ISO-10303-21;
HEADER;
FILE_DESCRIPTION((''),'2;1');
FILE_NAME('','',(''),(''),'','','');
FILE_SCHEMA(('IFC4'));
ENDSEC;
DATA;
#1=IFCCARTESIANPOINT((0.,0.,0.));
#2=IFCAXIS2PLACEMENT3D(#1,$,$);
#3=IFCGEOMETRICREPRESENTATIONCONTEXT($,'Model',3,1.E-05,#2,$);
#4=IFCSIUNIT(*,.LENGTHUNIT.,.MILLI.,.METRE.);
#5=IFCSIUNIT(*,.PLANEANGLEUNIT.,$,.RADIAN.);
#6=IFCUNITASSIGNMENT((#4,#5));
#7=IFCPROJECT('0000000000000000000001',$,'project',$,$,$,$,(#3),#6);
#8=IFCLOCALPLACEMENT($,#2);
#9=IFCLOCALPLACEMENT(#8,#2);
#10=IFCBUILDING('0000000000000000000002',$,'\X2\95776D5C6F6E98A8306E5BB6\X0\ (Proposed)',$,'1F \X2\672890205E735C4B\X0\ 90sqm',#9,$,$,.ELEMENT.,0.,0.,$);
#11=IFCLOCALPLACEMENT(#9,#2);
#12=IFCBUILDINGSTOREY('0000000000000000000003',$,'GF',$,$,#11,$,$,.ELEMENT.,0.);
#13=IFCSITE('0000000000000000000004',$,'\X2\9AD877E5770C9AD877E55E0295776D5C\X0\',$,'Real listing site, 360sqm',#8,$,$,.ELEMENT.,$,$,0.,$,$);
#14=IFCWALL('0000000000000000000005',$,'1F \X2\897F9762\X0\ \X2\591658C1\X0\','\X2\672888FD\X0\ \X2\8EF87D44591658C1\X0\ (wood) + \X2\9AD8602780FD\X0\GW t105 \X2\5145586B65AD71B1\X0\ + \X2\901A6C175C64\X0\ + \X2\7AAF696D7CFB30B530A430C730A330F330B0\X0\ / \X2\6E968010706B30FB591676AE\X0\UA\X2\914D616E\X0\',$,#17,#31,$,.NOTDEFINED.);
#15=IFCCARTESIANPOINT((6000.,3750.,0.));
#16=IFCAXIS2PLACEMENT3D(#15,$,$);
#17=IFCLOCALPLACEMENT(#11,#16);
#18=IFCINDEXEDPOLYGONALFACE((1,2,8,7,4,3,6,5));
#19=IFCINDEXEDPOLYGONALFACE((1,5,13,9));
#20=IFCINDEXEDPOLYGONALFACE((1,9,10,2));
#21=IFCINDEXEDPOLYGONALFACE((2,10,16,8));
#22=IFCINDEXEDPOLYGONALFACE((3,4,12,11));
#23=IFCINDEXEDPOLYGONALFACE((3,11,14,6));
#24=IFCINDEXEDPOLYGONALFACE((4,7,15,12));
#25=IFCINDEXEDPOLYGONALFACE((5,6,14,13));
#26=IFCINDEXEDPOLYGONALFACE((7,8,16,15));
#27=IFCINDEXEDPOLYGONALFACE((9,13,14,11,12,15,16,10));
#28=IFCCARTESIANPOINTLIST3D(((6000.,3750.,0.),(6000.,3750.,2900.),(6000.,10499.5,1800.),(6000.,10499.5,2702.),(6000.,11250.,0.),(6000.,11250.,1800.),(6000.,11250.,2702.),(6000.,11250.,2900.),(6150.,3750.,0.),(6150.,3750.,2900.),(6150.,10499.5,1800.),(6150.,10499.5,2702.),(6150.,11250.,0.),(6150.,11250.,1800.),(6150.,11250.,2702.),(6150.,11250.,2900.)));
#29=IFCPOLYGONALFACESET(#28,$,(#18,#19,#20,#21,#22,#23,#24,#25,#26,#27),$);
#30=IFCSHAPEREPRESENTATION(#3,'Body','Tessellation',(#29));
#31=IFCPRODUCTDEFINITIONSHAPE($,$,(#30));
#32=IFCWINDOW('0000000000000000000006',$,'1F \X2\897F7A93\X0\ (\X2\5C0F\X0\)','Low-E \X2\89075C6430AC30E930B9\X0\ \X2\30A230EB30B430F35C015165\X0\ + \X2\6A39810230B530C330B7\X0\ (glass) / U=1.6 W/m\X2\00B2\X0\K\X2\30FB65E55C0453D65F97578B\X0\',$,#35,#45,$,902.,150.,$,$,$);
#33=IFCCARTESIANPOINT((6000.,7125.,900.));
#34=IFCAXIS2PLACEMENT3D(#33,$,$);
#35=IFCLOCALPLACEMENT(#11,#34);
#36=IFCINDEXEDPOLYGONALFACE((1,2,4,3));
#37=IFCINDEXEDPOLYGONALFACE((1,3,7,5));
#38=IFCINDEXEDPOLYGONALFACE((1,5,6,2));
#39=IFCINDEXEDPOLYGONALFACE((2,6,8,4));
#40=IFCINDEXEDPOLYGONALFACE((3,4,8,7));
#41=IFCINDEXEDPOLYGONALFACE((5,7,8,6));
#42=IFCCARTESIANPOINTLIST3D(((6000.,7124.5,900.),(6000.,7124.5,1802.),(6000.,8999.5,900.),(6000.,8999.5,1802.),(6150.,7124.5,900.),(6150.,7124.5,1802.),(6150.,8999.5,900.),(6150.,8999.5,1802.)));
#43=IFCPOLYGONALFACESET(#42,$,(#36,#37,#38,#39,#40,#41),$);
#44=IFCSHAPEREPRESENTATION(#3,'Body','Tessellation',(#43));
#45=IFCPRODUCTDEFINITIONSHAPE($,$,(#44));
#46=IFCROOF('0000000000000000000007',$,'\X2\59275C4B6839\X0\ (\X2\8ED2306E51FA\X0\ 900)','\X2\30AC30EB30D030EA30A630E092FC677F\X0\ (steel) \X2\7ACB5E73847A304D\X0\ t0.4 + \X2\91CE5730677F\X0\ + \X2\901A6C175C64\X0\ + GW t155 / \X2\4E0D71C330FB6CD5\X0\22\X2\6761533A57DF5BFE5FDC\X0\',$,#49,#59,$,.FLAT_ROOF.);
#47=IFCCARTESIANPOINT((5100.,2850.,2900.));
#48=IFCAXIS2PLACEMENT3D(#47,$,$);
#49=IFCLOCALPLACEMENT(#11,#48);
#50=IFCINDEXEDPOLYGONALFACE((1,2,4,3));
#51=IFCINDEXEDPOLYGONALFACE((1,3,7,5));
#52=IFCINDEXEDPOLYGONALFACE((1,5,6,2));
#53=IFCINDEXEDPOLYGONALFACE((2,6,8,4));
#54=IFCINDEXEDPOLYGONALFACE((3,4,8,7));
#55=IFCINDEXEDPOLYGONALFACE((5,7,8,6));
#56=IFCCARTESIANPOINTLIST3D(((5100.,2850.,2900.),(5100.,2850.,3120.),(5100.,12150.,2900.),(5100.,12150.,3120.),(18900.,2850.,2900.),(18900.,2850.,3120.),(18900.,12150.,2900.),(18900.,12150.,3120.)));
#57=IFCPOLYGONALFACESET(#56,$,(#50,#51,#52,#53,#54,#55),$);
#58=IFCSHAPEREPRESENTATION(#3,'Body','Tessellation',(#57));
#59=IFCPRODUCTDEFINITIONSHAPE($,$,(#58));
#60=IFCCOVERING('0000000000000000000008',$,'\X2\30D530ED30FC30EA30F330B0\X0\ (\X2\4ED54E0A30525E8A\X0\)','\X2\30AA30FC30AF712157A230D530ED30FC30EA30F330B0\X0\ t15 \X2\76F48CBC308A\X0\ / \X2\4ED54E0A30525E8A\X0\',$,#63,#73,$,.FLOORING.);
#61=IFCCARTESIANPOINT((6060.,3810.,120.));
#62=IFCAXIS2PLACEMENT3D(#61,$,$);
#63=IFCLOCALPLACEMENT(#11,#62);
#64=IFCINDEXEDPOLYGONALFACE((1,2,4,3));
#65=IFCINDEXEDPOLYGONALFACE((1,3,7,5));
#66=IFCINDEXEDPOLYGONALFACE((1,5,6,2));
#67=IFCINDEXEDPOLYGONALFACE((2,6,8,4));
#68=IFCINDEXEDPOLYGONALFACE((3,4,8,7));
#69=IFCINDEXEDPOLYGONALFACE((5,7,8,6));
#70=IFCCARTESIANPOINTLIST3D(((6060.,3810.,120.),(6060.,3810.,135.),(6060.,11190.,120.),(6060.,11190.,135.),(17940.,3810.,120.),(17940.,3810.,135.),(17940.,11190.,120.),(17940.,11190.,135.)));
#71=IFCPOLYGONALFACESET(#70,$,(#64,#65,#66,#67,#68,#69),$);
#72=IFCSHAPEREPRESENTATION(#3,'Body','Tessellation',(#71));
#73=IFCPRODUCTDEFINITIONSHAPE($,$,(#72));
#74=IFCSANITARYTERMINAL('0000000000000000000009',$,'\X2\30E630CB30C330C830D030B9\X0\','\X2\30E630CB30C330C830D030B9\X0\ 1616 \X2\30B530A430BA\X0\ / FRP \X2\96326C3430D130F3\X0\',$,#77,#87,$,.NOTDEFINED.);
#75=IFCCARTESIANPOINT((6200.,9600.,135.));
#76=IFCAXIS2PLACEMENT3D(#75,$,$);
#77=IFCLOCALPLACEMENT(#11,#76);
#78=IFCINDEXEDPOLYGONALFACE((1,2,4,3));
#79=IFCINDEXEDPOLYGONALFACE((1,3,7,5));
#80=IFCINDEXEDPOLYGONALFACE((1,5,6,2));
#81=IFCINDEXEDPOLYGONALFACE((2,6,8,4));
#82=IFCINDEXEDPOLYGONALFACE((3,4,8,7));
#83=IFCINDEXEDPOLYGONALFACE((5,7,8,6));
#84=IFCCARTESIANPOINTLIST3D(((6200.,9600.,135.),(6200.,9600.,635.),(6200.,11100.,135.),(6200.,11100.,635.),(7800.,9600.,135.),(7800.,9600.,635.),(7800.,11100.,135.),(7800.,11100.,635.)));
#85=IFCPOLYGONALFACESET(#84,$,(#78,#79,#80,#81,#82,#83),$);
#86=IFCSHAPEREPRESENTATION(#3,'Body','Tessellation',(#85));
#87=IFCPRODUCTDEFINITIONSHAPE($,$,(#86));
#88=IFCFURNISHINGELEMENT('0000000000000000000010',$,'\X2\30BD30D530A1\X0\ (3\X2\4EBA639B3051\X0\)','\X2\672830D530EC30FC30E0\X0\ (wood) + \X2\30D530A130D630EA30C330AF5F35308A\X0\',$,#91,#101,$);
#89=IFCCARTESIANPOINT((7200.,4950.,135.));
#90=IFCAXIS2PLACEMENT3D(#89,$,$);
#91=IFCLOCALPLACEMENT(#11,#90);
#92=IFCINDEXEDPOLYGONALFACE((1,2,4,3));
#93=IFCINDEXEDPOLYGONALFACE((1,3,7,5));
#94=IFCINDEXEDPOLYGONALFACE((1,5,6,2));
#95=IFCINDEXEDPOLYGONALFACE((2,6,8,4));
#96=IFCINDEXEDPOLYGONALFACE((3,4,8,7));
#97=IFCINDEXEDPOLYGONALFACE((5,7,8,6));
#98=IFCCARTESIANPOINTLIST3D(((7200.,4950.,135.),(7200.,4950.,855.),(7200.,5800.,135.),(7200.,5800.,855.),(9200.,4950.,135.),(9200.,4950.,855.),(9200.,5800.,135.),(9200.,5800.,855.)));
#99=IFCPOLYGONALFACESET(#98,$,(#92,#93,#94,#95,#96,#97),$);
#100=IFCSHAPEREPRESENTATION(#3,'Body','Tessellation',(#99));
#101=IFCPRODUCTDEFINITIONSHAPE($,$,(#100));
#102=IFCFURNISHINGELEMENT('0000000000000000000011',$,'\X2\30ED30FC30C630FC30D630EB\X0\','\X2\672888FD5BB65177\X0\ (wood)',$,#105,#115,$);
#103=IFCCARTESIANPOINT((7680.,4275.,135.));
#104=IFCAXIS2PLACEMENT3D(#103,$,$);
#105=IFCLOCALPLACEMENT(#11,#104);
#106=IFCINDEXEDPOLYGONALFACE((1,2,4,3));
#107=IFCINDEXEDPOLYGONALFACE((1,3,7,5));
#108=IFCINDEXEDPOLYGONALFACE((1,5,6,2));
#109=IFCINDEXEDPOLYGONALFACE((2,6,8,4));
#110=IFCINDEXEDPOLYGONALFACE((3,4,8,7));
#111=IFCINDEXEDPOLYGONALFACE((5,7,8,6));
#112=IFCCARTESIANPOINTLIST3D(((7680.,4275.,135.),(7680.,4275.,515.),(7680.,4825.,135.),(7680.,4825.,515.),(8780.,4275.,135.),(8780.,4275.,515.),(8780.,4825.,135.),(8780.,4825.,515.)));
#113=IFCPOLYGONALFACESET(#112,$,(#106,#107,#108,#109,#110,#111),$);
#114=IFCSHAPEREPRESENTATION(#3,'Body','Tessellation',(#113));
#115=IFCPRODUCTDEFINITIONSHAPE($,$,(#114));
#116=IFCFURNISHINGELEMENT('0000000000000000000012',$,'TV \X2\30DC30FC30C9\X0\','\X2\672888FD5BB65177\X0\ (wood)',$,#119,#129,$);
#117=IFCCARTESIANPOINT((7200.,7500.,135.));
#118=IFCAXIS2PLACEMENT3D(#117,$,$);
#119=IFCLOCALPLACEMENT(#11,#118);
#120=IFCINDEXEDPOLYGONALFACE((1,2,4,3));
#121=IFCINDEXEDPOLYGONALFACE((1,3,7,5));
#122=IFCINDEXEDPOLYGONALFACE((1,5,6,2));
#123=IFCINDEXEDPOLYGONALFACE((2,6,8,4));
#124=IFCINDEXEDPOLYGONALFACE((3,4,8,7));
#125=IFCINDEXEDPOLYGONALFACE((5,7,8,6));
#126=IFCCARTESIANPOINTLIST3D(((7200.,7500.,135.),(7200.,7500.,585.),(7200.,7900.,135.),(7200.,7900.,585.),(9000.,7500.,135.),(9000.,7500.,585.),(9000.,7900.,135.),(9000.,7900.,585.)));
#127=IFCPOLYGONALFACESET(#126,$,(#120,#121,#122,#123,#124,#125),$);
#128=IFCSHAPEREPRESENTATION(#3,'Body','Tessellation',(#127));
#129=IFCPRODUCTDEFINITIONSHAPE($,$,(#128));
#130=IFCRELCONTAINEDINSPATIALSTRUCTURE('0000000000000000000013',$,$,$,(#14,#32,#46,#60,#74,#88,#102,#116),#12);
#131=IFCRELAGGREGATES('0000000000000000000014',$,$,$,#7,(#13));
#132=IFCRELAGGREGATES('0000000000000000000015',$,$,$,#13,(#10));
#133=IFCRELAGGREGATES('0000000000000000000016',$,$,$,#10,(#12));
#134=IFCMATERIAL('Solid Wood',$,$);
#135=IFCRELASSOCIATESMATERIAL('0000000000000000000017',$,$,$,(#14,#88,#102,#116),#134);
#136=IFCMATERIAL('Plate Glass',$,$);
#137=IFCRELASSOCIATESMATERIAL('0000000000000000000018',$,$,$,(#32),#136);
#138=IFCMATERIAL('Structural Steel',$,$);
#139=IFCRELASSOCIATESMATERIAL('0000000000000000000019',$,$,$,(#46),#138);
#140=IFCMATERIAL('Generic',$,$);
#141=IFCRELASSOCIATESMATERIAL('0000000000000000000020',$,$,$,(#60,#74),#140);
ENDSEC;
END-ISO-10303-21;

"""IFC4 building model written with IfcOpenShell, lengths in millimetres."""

from ifc_helpers import new_model, si_unit, frame, frame_2d, origin, place, context, project, spatial, rectangle, extrude, material, element, fill, save


model = new_model("IFC4")

# Units and contexts
model_context = context("Model", 3, precision=1e-05, world=origin())
ifc_project = project(units=[si_unit("LENGTHUNIT", "METRE", prefix="MILLI"), si_unit("PLANEANGLEUNIT", "RADIAN")], contexts=[model_context])

# Site, building, storey
site_placement = place(None, origin())
site = spatial("IfcSite", under=ifc_project, at=site_placement, Name="高知県高知市長浜", ObjectType="Real listing site, 360sqm", CompositionType="ELEMENT", RefElevation=0.0)
building_placement = place(site_placement, origin())
building = spatial("IfcBuilding", under=site, at=building_placement, Name="長浜潮風の家 (Proposed)", ObjectType="1F 木造平屋 90sqm", CompositionType="ELEMENT", ElevationOfRefHeight=0.0, ElevationOfTerrain=0.0)
storey_placement = place(building_placement, origin())
storey = spatial("IfcBuildingStorey", under=building, at=storey_placement, Name="GF", CompositionType="ELEMENT", Elevation=0.0)

# Shared definitions
ifc_material_1 = material(Name="Solid Wood")

# Shared definitions
ifc_material_2 = material(Name="Plate Glass")

# Wall, opening, window
wall_1_placement = place(storey_placement, frame((6000.0, 3750.0, 0.0)))
wall_1 = element("IfcWall", 1, at=wall_1_placement, inside=storey, material=ifc_material_1, Name="1F 西面 外壁", Description="木製 軸組外壁 (wood) + 高性能GW t105 充填断熱 + 通気層 + 窯業系サイディング / 準耐火・外皮UA配慮", PredefinedType="NOTDEFINED", context=model_context, shape_type="SweptSolid", body=[
    extrude(rectangle(XDim=150.0, YDim=7500.0, at=frame_2d((75.0, 3750.0))), frame((6000.0, 3750.0, 0.0)), (0.0, 0.0, 1.0), 2900.0),
])
opening_1_placement = place(storey_placement, frame((6000.0, 7125.0, 900.0)))
opening_1 = element("IfcOpeningElement", 2, at=opening_1_placement, cuts=wall_1, PredefinedType="NOTDEFINED", context=model_context, shape_type="SweptSolid", body=[
    extrude(rectangle(XDim=150.0, YDim=1875.0, at=frame_2d((75.0, 937.0))), frame((6000.0, 7125.0, 900.0)), (0.0, 0.0, 1.0), 902.0),
])
window_1_placement = place(storey_placement, frame((6000.0, 7125.0, 900.0)))
window_1 = element("IfcWindow", 3, at=window_1_placement, inside=storey, material=ifc_material_2, Name="1F 西窓 (小)", Description="Low-E 複層ガラス アルゴン封入 + 樹脂サッシ (glass) / U=1.6 W/m²K・日射取得型", OverallHeight=902.0, OverallWidth=150.0, context=model_context, shape_type="SweptSolid", body=[
    extrude(rectangle(XDim=150.0, YDim=1875.0, at=frame_2d((75.0, 937.0))), frame((6000.0, 7125.0, 900.0)), (0.0, 0.0, 1.0), 902.0),
])
fill(opening_1, window_1)

# Roof
ifc_material_3 = material(Name="Structural Steel")
roof_placement = place(storey_placement, frame((5100.0, 2850.0, 2900.0)))
element("IfcRoof", 4, at=roof_placement, inside=storey, material=ifc_material_3, Name="大屋根 (軒の出 900)", Description="ガルバリウム鋼板 (steel) 立平葺き t0.4 + 野地板 + 通気層 + GW t155 / 不燃・法22条区域対応", PredefinedType="FLAT_ROOF", context=model_context, shape_type="SweptSolid", body=[
    extrude(rectangle(XDim=13800.0, YDim=9300.0, at=frame_2d((6900.0, 4650.0))), frame((5100.0, 2850.0, 2900.0)), (0.0, 0.0, 1.0), 220.0),
])

# Covering
ifc_material_4 = material(Name="Generic")
covering_placement = place(storey_placement, frame((6060.0, 3810.0, 120.0)))
element("IfcCovering", 5, at=covering_placement, inside=storey, material=ifc_material_4, Name="フローリング (仕上げ床)", Description="オーク無垢フローリング t15 直貼り / 仕上げ床", PredefinedType="FLOORING", context=model_context, shape_type="SweptSolid", body=[
    extrude(rectangle(XDim=11880.0, YDim=7380.0, at=frame_2d((5940.0, 3690.0))), frame((6060.0, 3810.0, 120.0)), (0.0, 0.0, 1.0), 15.0),
])

# Sanitary terminal
sanitary_terminal_placement = place(storey_placement, frame((6200.0, 9600.0, 135.0)))
element("IfcSanitaryTerminal", 6, at=sanitary_terminal_placement, inside=storey, material=ifc_material_4, Name="ユニットバス", Description="ユニットバス 1616 サイズ / FRP 防水パン", PredefinedType="NOTDEFINED", context=model_context, shape_type="SweptSolid", body=[
    extrude(rectangle(XDim=1600.0, YDim=1500.0, at=frame_2d((800.0, 750.0))), frame((6200.0, 9600.0, 135.0)), (0.0, 0.0, 1.0), 500.0),
])

# Furnishing elements
furnishing_1_placement = place(storey_placement, frame((7200.0, 4950.0, 135.0)))
element("IfcFurnishingElement", 7, at=furnishing_1_placement, inside=storey, material=ifc_material_1, Name="ソファ (3人掛け)", Description="木フレーム (wood) + ファブリック張り", context=model_context, shape_type="SweptSolid", body=[
    extrude(rectangle(XDim=2000.0, YDim=850.0, at=frame_2d((1000.0, 425.0))), frame((7200.0, 4950.0, 135.0)), (0.0, 0.0, 1.0), 720.0),
])
furnishing_2_placement = place(storey_placement, frame((7680.0, 4275.0, 135.0)))
element("IfcFurnishingElement", 8, at=furnishing_2_placement, inside=storey, material=ifc_material_1, Name="ローテーブル", Description="木製家具 (wood)", context=model_context, shape_type="SweptSolid", body=[
    extrude(rectangle(XDim=1100.0, YDim=550.0, at=frame_2d((550.0, 275.0))), frame((7680.0, 4275.0, 135.0)), (0.0, 0.0, 1.0), 380.0),
])
furnishing_3_placement = place(storey_placement, frame((7200.0, 7500.0, 135.0)))
element("IfcFurnishingElement", 9, at=furnishing_3_placement, inside=storey, material=ifc_material_1, Name="TV ボード", Description="木製家具 (wood)", context=model_context, shape_type="SweptSolid", body=[
    extrude(rectangle(XDim=1800.0, YDim=400.0, at=frame_2d((900.0, 200.0))), frame((7200.0, 7500.0, 135.0)), (0.0, 0.0, 1.0), 450.0),
])

save(model, "model.ifc")
